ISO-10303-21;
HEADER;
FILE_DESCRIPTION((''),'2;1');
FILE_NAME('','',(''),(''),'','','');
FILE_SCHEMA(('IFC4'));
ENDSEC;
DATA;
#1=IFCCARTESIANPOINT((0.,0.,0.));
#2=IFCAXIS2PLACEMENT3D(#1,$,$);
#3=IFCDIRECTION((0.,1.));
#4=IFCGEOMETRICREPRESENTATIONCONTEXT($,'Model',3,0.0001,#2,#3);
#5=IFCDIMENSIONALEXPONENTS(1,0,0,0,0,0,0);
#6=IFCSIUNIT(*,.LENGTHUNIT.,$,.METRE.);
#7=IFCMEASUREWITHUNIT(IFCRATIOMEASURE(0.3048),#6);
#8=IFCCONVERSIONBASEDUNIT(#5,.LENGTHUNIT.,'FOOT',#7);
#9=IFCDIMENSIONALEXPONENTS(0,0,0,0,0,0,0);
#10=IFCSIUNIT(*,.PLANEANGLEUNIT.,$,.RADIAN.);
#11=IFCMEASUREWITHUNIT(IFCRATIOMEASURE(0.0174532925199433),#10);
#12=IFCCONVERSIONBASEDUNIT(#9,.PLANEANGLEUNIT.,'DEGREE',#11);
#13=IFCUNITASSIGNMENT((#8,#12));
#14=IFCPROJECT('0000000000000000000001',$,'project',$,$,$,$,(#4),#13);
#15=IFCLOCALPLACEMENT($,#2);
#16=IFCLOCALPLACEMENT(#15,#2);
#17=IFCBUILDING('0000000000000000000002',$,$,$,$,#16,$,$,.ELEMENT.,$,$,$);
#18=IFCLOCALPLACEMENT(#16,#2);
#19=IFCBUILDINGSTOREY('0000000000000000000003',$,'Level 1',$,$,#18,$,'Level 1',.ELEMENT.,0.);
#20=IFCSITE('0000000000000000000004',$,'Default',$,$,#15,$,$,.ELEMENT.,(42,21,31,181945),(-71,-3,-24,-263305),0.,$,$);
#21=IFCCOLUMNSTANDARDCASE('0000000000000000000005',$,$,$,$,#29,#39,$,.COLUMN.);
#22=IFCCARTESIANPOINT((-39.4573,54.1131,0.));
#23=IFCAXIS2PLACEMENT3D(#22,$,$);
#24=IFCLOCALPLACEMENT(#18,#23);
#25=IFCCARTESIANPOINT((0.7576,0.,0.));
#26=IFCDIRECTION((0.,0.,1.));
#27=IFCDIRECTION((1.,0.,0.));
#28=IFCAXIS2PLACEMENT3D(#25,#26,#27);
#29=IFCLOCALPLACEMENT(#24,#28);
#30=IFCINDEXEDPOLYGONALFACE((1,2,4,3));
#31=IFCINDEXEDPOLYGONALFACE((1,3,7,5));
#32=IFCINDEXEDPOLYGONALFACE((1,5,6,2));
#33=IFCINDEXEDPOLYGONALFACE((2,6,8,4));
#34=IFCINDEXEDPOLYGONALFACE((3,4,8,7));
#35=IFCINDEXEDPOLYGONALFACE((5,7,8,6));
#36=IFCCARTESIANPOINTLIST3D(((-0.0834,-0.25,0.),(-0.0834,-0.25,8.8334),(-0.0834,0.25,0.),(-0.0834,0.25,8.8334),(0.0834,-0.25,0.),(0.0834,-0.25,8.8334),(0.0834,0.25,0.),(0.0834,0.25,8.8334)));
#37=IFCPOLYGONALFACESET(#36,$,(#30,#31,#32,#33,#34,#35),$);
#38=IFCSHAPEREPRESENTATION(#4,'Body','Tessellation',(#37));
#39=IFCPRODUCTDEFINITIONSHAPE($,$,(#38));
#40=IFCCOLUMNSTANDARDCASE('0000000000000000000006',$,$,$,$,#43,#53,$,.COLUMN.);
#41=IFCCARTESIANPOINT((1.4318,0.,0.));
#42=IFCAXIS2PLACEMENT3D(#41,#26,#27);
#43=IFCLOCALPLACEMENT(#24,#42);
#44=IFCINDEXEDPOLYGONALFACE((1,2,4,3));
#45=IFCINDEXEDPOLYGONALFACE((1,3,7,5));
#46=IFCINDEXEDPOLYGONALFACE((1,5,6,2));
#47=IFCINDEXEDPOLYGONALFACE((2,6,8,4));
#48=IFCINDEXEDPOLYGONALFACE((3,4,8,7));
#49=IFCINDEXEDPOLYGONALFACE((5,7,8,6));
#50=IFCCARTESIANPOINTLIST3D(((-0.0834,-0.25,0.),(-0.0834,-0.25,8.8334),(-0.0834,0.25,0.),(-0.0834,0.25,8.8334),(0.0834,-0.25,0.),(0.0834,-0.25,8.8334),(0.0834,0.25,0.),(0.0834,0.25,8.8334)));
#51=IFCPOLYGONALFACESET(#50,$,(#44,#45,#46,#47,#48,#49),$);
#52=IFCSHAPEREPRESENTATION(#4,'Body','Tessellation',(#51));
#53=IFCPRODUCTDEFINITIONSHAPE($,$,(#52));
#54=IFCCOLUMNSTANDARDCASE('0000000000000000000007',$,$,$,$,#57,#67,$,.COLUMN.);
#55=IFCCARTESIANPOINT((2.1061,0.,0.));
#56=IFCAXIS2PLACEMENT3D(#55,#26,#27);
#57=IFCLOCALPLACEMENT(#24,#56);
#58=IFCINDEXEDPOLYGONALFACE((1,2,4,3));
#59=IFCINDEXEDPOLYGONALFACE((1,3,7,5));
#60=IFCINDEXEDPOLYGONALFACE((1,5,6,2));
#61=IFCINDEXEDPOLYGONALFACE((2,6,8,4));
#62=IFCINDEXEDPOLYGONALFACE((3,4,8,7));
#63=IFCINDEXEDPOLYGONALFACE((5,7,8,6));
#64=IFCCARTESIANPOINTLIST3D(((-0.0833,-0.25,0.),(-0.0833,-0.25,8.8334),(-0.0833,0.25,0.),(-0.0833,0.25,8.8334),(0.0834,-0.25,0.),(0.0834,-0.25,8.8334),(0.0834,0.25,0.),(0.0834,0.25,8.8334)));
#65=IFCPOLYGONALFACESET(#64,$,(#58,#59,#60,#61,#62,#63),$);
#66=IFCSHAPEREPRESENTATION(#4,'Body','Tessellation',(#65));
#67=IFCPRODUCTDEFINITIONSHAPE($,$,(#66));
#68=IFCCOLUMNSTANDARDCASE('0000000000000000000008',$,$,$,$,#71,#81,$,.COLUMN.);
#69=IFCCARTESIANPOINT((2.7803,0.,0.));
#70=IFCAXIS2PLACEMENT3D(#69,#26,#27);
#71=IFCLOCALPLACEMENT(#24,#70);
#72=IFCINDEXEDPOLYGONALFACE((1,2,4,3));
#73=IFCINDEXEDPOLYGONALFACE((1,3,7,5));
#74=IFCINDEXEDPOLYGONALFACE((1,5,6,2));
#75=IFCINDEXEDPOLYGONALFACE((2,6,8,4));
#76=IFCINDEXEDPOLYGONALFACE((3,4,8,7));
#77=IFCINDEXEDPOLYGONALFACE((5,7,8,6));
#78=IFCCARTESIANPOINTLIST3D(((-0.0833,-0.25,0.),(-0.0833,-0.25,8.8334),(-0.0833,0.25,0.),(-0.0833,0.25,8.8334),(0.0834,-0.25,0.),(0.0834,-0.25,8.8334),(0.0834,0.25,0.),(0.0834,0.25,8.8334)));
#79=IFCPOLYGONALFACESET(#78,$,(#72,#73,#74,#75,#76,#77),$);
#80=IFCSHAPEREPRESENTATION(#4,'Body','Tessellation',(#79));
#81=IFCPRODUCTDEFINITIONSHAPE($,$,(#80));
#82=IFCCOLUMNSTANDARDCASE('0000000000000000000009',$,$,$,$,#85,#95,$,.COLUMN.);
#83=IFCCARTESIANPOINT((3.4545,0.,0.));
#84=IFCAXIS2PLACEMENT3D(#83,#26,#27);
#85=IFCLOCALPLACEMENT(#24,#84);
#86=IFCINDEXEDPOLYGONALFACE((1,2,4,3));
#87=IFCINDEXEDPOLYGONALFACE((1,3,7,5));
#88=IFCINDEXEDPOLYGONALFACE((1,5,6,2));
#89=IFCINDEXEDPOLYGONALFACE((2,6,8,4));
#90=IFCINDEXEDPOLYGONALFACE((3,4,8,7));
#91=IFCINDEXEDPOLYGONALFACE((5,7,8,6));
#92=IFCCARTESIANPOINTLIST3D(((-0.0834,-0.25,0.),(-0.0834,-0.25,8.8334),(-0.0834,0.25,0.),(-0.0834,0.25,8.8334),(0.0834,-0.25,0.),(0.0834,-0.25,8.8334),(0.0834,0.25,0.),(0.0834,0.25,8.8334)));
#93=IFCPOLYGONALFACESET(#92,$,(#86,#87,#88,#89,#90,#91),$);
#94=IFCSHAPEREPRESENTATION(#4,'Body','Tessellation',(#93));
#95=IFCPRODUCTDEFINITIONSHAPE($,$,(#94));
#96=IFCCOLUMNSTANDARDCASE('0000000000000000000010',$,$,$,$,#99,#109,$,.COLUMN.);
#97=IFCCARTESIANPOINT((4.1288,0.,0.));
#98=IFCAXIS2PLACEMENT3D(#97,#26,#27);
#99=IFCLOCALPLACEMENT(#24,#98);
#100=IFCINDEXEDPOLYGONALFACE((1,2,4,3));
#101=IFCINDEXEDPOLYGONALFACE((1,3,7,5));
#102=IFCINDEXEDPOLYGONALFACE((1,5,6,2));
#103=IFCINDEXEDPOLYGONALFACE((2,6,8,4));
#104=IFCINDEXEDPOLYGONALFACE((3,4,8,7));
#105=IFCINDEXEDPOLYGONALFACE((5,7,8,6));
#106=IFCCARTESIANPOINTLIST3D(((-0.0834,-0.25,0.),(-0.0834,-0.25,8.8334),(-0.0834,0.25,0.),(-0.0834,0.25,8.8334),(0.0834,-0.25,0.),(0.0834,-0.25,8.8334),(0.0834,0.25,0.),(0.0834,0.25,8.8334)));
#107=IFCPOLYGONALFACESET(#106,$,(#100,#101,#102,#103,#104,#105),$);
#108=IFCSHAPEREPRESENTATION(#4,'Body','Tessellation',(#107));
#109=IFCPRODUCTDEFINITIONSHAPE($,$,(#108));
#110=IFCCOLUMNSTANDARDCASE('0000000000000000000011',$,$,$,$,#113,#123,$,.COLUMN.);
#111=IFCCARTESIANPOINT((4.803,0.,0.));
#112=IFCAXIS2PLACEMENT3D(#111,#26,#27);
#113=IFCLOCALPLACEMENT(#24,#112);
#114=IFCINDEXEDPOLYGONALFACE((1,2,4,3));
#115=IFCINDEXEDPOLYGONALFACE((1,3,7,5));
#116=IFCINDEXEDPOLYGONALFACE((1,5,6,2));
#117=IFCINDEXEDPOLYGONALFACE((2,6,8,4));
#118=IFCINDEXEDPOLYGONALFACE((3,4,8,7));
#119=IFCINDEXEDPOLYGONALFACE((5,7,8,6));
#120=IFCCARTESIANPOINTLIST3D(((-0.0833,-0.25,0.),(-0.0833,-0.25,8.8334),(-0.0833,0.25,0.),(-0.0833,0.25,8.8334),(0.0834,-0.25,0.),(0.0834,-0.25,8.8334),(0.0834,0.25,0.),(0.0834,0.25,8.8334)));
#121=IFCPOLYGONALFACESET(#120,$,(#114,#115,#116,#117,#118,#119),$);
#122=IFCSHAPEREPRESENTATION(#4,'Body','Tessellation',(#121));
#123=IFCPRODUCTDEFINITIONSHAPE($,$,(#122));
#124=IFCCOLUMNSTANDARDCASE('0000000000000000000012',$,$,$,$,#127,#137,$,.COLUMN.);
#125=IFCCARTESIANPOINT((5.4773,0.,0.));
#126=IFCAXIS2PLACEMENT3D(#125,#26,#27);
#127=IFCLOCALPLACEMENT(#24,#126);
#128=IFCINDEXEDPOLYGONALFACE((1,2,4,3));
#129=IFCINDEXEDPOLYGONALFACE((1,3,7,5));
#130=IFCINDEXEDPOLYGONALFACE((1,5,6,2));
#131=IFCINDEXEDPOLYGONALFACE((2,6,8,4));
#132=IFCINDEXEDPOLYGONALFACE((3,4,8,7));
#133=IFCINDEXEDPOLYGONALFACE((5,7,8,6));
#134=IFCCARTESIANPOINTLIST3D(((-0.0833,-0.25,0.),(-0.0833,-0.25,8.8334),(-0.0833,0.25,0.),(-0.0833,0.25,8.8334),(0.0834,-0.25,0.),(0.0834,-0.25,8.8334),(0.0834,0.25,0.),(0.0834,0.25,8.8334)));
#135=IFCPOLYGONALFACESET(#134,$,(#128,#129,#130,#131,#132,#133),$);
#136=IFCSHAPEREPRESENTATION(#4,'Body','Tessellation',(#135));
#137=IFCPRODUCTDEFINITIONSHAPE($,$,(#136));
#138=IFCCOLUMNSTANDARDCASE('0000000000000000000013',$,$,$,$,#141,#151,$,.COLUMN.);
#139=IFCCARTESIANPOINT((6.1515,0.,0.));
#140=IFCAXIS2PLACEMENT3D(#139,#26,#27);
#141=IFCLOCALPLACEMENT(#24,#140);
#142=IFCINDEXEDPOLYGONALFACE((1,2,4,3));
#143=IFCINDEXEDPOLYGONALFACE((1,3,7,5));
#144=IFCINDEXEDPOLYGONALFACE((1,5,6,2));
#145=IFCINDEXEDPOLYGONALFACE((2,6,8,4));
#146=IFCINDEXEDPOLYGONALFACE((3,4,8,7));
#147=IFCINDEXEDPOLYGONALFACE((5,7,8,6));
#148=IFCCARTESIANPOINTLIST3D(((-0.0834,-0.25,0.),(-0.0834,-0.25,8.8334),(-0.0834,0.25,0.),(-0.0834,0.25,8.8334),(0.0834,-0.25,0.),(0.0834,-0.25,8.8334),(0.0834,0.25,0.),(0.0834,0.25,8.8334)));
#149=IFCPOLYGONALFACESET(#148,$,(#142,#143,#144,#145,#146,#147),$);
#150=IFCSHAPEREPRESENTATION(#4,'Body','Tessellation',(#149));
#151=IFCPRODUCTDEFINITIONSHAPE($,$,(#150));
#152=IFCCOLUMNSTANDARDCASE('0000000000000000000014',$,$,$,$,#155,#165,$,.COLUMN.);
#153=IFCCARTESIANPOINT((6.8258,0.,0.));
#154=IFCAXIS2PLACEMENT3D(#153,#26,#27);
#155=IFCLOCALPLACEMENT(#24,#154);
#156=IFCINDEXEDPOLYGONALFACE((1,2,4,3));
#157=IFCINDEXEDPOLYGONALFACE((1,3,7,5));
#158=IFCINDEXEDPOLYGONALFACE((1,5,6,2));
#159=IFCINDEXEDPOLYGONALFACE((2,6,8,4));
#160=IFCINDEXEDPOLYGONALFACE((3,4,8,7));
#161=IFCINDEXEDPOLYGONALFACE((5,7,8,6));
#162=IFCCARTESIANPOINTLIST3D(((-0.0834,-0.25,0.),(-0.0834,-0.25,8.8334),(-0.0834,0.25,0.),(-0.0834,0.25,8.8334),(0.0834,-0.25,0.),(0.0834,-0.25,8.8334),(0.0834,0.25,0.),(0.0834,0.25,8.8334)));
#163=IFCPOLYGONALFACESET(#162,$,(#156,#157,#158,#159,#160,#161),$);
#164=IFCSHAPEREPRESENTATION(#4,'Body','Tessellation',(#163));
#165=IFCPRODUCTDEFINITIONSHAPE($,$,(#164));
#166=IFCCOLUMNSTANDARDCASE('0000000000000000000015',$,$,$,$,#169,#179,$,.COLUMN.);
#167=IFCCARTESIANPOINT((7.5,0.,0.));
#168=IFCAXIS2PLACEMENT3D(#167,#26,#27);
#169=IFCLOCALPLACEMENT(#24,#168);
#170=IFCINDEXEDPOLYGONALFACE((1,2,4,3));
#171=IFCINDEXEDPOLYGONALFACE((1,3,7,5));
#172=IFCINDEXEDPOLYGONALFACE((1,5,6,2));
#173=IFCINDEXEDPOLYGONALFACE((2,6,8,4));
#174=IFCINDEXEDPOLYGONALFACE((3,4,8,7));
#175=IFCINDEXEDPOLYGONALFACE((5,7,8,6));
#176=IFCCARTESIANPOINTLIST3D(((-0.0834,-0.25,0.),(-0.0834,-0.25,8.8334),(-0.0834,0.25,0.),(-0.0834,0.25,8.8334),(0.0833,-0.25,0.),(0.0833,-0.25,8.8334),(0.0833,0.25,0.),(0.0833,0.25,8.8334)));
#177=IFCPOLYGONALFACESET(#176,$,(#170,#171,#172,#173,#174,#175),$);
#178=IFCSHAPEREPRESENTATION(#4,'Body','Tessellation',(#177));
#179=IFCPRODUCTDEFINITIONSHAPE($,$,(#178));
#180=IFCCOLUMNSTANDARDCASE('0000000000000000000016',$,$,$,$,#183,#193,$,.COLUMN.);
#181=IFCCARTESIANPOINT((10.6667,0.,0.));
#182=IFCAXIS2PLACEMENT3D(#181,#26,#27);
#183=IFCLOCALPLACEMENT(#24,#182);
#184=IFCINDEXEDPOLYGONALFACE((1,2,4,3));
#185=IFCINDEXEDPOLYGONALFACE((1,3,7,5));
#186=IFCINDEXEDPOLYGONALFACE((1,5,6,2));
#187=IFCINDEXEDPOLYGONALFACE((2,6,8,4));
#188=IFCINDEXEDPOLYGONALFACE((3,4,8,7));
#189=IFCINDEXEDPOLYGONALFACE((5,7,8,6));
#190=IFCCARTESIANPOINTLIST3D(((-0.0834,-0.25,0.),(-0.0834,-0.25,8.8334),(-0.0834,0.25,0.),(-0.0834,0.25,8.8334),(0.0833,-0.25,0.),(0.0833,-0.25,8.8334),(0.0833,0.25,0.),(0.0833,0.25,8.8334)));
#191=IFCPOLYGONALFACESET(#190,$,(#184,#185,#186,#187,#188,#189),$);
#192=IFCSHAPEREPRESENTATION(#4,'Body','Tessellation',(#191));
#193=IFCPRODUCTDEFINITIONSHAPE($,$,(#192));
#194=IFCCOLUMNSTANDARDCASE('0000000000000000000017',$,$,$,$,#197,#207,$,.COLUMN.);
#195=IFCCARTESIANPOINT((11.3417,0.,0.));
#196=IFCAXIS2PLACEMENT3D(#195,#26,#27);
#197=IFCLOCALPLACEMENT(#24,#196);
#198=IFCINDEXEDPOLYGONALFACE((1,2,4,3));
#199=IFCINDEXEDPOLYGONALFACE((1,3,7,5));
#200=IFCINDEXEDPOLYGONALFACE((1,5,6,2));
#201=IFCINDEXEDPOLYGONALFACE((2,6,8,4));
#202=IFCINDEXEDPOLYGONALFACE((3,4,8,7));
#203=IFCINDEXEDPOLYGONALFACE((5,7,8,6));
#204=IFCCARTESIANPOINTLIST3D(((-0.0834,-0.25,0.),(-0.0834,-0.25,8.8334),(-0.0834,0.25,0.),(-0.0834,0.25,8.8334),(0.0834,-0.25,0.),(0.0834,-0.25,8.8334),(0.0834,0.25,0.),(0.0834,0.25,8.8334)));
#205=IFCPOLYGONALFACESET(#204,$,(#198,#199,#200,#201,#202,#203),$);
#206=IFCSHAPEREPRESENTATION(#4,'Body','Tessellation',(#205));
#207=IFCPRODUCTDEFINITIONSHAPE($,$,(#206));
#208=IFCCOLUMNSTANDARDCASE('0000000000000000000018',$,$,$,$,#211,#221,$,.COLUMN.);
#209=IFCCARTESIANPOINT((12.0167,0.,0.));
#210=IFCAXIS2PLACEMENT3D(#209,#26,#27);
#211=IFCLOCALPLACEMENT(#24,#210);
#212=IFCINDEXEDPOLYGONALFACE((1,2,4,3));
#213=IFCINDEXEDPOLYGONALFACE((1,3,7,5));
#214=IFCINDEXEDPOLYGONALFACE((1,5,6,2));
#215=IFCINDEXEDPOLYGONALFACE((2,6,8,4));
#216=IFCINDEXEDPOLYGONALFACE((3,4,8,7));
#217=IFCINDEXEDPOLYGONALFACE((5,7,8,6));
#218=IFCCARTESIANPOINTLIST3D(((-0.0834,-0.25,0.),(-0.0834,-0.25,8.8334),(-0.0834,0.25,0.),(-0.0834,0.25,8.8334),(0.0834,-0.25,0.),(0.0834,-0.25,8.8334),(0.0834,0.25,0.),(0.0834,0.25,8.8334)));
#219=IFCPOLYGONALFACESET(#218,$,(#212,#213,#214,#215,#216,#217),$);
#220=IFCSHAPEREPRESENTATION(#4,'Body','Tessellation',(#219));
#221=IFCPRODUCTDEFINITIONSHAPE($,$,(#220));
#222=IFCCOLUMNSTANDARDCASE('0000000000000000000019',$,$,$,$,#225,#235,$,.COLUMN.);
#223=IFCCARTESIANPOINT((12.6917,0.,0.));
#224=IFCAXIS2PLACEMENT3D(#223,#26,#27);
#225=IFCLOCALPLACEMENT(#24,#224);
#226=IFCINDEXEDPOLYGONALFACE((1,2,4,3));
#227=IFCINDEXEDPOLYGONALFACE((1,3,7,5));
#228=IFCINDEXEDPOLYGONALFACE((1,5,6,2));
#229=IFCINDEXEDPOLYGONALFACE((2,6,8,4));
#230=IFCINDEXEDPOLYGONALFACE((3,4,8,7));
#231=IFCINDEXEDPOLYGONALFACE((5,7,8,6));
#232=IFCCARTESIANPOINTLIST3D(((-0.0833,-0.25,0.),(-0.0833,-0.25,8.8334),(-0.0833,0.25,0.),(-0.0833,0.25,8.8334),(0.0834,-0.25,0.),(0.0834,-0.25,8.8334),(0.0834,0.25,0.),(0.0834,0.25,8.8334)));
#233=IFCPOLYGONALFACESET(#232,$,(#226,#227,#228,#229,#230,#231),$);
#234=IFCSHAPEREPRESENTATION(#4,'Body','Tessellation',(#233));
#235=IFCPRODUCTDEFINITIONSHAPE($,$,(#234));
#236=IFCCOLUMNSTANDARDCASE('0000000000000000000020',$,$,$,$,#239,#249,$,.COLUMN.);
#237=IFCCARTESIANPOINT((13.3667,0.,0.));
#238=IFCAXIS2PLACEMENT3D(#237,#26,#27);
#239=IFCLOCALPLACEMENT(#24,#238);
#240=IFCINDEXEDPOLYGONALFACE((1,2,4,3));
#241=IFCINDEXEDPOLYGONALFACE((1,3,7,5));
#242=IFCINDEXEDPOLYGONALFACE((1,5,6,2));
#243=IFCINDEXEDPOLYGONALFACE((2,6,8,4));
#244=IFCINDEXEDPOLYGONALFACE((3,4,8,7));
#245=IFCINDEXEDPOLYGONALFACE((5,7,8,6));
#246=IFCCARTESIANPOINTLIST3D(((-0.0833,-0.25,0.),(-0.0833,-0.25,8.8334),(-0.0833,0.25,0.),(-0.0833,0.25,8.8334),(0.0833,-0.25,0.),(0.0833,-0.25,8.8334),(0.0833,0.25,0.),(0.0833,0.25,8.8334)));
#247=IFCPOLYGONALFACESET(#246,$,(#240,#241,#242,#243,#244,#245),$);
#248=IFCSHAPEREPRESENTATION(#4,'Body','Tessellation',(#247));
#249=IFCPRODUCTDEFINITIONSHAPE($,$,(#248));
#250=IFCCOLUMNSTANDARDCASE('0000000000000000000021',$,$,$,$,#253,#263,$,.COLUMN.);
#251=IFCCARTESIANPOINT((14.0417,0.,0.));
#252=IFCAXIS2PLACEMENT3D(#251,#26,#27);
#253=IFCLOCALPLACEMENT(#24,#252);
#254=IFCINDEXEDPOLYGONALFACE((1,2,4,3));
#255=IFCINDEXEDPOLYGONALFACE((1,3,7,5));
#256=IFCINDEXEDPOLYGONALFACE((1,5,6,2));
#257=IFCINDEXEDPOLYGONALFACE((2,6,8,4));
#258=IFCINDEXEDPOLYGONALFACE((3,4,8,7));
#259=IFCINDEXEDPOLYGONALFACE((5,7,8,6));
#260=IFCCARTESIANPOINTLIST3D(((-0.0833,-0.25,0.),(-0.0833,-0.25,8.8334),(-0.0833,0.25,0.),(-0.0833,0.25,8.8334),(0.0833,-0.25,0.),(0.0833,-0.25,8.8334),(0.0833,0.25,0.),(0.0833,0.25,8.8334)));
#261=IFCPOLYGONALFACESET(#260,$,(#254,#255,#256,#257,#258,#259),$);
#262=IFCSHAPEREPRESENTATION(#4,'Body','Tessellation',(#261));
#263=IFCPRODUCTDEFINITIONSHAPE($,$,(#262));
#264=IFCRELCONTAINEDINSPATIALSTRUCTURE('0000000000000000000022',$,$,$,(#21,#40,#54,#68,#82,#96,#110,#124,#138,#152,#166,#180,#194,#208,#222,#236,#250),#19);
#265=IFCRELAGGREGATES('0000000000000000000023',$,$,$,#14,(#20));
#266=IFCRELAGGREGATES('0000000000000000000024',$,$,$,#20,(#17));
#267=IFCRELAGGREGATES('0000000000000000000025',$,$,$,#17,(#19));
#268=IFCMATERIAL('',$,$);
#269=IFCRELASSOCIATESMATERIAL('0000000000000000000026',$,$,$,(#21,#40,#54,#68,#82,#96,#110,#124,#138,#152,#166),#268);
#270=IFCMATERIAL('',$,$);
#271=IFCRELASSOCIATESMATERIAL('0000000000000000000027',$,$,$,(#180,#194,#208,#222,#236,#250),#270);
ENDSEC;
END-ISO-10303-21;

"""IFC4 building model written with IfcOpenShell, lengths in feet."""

from ifc_helpers import new_model, entity, si_unit, converted_unit, direction, frame, origin, place, context, project, spatial, rectangle, extrude, material, element, save


model = new_model("IFC4")

# Units and contexts
model_context = context("Model", 3, precision=0.0001, world=origin(), true_north=direction((0.0, 1.0)))
ifc_project = project(units=[converted_unit("LENGTHUNIT", "FOOT", entity("IfcRatioMeasure", 0.3048), si_unit("LENGTHUNIT", "METRE"), dimensions=[1, 0, 0, 0, 0, 0, 0]), converted_unit("PLANEANGLEUNIT", "DEGREE", entity("IfcRatioMeasure", 0.0174532925199433), si_unit("PLANEANGLEUNIT", "RADIAN"), dimensions=[0, 0, 0, 0, 0, 0, 0])], contexts=[model_context])

# Site, building, storey
site_placement = place(None, origin())
site = spatial("IfcSite", under=ifc_project, at=site_placement, Name="Default", CompositionType="ELEMENT", RefLatitude=(42, 21, 31, 181945), RefLongitude=(-71, -3, -24, -263305), RefElevation=0.0)
building_placement = place(site_placement, origin())
building = spatial("IfcBuilding", under=site, at=building_placement, CompositionType="ELEMENT")
storey_placement = place(building_placement, origin())
storey = spatial("IfcBuildingStorey", under=building, at=storey_placement, Name="Level 1", LongName="Level 1", CompositionType="ELEMENT", Elevation=0.0)

# Columns
ifc_material_1 = material(Name="")
placement_1 = place(storey_placement, frame((-39.4573, 54.1131, 0.0)))
for number, where, z_axis, x_axis in (
    (1, (0.7576, 0.0, 0.0), (0.0, 0.0, 1.0), (1.0, 0.0, 0.0)),
    (2, (1.4318, 0.0, 0.0), (0.0, 0.0, 1.0), (1.0, 0.0, 0.0)),
    (3, (2.1061, 0.0, 0.0), (0.0, 0.0, 1.0), (1.0, 0.0, 0.0)),
    (4, (2.7803, 0.0, 0.0), (0.0, 0.0, 1.0), (1.0, 0.0, 0.0)),
    (5, (3.4545, 0.0, 0.0), (0.0, 0.0, 1.0), (1.0, 0.0, 0.0)),
    (6, (4.1288, 0.0, 0.0), (0.0, 0.0, 1.0), (1.0, 0.0, 0.0)),
    (7, (4.803, 0.0, 0.0), (0.0, 0.0, 1.0), (1.0, 0.0, 0.0)),
    (8, (5.4773, 0.0, 0.0), (0.0, 0.0, 1.0), (1.0, 0.0, 0.0)),
    (9, (6.1515, 0.0, 0.0), (0.0, 0.0, 1.0), (1.0, 0.0, 0.0)),
    (10, (6.8258, 0.0, 0.0), (0.0, 0.0, 1.0), (1.0, 0.0, 0.0)),
    (11, (7.5, 0.0, 0.0), (0.0, 0.0, 1.0), (1.0, 0.0, 0.0)),
):
    element("IfcColumnStandardCase", number, at=place(placement_1, frame(where, z_axis=z_axis, x_axis=x_axis)), inside=storey, material=ifc_material_1, PredefinedType="COLUMN", context=model_context, shape_type="SweptSolid", body=[
        extrude(rectangle(XDim=0.1667, YDim=0.5), origin(), (0.0, 0.0, 1.0), 8.8334),
    ])
ifc_material_2 = material(Name="")
for number, where, z_axis, x_axis in (
    (12, (10.6667, 0.0, 0.0), (0.0, 0.0, 1.0), (1.0, 0.0, 0.0)),
    (13, (11.3417, 0.0, 0.0), (0.0, 0.0, 1.0), (1.0, 0.0, 0.0)),
    (14, (12.0167, 0.0, 0.0), (0.0, 0.0, 1.0), (1.0, 0.0, 0.0)),
    (15, (12.6917, 0.0, 0.0), (0.0, 0.0, 1.0), (1.0, 0.0, 0.0)),
    (16, (13.3667, 0.0, 0.0), (0.0, 0.0, 1.0), (1.0, 0.0, 0.0)),
    (17, (14.0417, 0.0, 0.0), (0.0, 0.0, 1.0), (1.0, 0.0, 0.0)),
):
    element("IfcColumnStandardCase", number, at=place(placement_1, frame(where, z_axis=z_axis, x_axis=x_axis)), inside=storey, material=ifc_material_2, PredefinedType="COLUMN", context=model_context, shape_type="SweptSolid", body=[
        extrude(rectangle(XDim=0.1667, YDim=0.5), origin(), (0.0, 0.0, 1.0), 8.8334),
    ])

save(model, "model.ifc")
